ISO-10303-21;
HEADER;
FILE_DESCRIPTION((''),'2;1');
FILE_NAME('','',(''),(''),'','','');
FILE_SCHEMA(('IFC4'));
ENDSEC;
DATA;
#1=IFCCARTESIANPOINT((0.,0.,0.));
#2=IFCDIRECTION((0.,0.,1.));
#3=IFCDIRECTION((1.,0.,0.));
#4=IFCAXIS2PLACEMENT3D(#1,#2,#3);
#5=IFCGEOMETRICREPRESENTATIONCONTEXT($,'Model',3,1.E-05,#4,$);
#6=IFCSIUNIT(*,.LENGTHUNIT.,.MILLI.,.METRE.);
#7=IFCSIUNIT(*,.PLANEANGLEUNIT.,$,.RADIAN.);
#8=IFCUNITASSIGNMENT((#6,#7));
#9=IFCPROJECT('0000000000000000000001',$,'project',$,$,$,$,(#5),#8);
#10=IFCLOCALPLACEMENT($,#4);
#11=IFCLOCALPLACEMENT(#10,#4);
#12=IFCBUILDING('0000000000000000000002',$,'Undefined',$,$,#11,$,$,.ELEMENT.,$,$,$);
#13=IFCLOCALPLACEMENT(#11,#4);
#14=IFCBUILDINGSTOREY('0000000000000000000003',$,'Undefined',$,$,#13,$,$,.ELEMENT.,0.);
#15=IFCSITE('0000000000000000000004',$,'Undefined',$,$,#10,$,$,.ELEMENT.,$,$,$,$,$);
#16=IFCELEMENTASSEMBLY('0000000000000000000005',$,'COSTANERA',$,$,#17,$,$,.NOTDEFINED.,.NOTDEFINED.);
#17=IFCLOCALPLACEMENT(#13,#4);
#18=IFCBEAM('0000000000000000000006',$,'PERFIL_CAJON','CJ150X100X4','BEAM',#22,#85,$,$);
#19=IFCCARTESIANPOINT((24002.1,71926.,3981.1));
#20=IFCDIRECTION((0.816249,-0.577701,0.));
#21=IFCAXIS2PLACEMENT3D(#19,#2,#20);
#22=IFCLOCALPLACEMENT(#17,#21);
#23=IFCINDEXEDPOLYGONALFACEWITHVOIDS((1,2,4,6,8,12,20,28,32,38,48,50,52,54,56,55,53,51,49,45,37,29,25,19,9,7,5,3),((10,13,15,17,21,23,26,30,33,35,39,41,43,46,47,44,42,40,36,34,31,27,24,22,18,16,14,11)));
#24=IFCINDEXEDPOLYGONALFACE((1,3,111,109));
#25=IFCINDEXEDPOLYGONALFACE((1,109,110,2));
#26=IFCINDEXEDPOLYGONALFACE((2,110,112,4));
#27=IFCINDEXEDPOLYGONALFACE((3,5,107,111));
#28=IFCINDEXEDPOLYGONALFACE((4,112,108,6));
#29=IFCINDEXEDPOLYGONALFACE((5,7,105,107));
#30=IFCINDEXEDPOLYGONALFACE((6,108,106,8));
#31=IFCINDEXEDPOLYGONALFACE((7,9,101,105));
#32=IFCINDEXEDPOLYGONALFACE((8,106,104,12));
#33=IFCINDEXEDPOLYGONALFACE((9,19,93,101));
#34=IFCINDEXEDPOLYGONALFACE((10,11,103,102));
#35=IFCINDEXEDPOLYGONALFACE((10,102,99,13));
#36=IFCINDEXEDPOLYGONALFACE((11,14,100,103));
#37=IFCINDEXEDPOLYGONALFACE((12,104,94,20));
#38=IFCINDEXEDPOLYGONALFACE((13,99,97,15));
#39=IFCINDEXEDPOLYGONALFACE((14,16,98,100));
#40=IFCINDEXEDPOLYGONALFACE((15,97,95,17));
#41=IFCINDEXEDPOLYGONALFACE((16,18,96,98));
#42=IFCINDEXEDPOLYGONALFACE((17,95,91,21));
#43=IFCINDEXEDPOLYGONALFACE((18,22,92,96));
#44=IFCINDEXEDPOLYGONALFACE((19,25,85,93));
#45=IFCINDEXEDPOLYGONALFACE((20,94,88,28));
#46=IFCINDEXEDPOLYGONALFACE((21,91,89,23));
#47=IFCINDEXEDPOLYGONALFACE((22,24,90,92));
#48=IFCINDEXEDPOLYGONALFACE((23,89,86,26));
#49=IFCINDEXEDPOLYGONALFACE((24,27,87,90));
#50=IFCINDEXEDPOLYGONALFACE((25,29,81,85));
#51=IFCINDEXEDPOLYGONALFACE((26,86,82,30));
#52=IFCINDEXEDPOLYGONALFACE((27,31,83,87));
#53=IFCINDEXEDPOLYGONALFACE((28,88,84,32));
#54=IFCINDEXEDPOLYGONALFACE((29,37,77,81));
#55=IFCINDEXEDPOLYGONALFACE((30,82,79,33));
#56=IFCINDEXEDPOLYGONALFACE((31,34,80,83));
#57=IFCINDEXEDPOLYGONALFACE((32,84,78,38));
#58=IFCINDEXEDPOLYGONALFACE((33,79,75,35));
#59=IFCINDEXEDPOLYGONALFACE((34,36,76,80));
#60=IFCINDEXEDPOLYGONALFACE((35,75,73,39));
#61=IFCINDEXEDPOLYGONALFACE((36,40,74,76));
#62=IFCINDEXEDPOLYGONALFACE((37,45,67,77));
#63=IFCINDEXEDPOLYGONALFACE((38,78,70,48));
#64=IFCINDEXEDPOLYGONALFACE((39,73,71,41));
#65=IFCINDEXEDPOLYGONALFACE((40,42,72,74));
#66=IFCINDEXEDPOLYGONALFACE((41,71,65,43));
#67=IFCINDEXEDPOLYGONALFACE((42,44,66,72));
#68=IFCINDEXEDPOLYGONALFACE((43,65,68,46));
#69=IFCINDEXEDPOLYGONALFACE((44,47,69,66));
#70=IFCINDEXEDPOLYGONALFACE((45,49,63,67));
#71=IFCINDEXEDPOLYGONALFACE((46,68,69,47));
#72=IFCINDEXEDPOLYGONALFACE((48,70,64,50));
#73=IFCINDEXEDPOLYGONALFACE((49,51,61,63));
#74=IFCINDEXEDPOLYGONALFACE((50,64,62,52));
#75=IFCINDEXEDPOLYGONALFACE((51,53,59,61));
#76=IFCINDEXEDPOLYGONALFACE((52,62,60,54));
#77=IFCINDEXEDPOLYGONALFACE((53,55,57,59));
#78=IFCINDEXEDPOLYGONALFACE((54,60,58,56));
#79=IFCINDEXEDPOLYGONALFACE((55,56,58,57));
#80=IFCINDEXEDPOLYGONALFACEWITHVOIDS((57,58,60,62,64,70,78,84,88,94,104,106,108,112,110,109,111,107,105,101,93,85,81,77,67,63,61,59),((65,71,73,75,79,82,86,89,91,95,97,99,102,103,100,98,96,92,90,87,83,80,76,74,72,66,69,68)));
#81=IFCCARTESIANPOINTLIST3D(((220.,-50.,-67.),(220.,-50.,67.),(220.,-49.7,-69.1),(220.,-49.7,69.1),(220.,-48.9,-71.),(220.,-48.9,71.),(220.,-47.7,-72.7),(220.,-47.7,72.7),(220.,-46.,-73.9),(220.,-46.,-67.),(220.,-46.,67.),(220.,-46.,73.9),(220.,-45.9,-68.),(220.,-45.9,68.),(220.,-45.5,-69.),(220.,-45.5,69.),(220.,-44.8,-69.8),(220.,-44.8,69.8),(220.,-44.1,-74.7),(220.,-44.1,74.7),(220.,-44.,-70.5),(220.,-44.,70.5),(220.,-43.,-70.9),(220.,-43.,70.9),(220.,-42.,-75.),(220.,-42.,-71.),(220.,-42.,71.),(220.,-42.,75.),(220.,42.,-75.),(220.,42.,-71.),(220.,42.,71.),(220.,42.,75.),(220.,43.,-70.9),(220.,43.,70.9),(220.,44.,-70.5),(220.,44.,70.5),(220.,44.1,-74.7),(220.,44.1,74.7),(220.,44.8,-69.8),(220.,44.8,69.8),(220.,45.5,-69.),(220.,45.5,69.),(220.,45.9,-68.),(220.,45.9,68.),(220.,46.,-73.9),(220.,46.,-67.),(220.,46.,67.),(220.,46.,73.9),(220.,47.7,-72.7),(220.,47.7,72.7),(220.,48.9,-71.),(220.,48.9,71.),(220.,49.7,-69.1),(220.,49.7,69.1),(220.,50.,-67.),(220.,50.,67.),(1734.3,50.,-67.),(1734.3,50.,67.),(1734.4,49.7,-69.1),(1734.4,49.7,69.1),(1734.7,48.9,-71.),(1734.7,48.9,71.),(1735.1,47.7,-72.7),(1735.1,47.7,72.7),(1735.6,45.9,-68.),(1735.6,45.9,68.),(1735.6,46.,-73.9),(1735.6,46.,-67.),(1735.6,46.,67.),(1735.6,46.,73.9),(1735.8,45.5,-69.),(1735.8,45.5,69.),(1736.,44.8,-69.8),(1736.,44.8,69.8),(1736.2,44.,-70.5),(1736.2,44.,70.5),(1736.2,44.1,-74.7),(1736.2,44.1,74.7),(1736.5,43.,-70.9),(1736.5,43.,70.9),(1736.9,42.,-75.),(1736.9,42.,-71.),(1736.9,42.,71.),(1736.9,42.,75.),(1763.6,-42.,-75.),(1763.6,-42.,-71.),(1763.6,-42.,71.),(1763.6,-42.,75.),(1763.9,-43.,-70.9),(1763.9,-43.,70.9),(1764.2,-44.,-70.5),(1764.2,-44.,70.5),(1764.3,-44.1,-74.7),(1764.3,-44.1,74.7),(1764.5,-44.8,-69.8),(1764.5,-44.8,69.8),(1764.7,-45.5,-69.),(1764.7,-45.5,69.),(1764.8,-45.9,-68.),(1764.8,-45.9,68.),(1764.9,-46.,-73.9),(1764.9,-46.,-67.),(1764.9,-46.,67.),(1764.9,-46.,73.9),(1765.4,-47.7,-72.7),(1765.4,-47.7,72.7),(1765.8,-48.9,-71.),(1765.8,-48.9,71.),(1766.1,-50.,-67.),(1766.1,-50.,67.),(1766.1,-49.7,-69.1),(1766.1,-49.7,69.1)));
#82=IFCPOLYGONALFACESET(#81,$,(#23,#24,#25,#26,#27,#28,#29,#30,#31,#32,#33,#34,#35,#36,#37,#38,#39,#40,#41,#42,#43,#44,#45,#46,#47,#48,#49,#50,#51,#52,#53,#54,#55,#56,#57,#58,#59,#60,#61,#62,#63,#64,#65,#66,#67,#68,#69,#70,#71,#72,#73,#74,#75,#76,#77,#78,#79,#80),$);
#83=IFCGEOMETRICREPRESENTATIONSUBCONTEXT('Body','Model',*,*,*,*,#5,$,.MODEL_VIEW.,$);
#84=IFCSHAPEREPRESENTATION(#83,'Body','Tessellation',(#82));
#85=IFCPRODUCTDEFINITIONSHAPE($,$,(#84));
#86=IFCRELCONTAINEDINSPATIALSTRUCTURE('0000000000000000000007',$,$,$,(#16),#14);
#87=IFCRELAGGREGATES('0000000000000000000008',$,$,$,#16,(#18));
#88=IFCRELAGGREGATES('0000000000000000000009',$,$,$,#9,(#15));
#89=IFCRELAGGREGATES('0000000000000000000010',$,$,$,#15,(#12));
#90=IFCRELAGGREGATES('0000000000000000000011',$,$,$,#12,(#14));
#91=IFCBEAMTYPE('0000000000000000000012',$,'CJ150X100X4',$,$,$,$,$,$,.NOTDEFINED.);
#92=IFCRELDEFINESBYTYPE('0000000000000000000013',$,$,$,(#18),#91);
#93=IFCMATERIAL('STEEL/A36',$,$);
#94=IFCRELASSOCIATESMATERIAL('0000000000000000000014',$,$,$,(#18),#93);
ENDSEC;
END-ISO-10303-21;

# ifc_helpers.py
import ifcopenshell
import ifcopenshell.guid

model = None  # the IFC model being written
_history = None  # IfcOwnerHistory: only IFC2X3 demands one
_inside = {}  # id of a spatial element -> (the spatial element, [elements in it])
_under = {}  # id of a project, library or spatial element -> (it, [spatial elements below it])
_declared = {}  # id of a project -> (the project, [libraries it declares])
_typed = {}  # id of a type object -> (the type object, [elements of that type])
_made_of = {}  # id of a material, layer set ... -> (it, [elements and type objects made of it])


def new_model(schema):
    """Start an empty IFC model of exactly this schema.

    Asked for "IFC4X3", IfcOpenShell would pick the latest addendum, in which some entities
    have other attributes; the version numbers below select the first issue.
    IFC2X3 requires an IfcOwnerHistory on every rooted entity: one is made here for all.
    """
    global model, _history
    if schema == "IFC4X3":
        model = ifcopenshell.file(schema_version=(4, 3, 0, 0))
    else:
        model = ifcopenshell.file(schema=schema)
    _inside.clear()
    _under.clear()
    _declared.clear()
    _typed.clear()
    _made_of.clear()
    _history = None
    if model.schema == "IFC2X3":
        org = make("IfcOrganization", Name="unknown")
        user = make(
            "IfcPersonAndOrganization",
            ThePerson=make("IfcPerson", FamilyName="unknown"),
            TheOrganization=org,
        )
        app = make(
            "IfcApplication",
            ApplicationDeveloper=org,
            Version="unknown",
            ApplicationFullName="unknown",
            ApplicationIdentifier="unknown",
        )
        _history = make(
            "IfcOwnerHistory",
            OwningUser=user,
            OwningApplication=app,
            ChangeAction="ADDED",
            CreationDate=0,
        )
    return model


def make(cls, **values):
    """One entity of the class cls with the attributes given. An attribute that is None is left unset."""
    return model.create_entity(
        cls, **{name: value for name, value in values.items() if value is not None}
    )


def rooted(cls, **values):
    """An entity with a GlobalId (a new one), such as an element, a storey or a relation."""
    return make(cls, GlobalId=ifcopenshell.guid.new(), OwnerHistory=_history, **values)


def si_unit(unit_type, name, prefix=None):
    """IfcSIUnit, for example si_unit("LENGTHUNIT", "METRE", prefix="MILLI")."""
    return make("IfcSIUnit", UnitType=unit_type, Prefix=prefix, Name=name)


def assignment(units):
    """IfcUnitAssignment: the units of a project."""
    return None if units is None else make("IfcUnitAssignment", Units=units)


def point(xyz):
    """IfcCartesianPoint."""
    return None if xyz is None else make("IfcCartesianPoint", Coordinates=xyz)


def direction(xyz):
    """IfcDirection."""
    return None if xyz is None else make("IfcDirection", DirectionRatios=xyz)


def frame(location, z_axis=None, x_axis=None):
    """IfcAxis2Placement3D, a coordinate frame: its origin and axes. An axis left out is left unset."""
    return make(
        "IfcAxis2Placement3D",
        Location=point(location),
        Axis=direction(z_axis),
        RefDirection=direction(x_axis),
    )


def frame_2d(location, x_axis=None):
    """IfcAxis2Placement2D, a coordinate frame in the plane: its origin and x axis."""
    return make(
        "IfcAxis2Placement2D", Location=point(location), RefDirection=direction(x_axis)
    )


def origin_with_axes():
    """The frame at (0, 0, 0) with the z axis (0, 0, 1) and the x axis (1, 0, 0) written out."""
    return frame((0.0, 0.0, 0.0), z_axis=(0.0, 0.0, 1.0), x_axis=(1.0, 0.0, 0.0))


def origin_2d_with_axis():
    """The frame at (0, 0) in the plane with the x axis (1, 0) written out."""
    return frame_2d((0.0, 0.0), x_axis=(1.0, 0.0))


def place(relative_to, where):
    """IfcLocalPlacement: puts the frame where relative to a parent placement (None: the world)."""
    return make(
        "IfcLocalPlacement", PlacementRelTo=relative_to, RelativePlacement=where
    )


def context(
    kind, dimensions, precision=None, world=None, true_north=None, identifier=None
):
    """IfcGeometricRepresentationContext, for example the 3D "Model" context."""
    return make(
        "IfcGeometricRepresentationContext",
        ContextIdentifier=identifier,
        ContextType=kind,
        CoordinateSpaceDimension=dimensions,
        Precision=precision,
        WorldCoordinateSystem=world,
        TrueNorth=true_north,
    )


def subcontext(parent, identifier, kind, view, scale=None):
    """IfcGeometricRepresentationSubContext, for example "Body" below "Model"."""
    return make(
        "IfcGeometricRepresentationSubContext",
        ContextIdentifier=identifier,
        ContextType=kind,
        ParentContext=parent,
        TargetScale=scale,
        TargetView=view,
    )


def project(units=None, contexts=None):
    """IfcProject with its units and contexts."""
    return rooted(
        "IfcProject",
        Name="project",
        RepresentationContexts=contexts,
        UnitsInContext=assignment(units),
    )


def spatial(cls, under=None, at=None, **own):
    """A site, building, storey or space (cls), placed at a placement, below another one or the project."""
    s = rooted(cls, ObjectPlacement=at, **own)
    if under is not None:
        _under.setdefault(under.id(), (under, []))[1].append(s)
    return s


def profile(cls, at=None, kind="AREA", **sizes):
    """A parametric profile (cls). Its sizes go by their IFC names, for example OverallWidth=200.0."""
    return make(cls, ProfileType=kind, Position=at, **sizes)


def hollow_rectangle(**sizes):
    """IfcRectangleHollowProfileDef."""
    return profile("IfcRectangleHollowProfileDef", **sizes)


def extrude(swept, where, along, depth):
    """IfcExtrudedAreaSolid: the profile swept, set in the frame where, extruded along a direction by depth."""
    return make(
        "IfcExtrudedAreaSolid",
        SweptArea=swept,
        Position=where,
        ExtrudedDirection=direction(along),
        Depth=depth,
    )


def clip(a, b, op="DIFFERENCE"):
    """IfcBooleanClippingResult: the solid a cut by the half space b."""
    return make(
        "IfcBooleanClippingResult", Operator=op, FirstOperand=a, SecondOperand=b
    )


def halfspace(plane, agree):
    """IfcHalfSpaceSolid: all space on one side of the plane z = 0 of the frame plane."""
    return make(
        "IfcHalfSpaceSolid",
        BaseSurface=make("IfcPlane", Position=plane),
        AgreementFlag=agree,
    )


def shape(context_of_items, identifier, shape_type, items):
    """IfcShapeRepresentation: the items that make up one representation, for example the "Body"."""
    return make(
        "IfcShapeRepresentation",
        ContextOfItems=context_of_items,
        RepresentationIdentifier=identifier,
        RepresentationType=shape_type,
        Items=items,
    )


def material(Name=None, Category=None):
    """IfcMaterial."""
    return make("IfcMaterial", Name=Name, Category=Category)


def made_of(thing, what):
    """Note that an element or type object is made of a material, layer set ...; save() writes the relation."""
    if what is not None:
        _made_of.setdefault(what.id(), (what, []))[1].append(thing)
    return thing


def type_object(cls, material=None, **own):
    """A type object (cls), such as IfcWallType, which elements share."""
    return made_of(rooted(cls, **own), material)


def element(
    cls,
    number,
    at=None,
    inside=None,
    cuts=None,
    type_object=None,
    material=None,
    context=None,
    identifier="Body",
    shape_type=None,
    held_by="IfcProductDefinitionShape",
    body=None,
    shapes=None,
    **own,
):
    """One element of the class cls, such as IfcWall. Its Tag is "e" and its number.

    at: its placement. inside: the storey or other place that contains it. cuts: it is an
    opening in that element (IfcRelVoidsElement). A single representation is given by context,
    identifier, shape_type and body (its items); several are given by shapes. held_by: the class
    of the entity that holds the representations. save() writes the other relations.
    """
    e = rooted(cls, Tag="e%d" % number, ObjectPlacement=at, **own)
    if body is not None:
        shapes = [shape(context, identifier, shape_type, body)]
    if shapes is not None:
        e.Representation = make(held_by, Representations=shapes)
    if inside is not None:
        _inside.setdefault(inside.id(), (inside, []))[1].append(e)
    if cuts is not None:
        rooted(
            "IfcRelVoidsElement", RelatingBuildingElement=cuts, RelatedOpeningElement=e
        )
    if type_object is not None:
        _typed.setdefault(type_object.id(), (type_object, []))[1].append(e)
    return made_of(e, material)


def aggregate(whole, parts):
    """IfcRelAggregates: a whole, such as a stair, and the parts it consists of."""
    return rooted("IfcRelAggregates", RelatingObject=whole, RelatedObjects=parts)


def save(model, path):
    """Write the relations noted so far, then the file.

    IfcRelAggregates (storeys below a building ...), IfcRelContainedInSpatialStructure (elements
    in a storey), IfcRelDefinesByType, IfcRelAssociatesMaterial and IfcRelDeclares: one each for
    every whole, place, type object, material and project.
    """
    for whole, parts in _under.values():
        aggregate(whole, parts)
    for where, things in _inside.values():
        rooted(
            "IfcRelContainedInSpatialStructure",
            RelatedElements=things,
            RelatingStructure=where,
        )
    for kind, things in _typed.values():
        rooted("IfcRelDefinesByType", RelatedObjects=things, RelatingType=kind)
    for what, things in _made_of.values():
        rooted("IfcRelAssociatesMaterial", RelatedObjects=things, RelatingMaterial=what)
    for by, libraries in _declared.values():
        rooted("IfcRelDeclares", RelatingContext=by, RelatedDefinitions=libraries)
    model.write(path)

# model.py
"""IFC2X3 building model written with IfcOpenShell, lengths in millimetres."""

from ifc_helpers import new_model, si_unit, frame, origin_with_axes, origin_2d_with_axis, place, context, subcontext, project, spatial, hollow_rectangle, extrude, clip, halfspace, material, type_object, element, aggregate, save


model = new_model("IFC2X3")

# Units and contexts
model_context = context("Model", 3, precision=1e-05, world=origin_with_axes())
body_context = subcontext(model_context, "Body", "Model", "MODEL_VIEW")
ifc_project = project(units=[si_unit("LENGTHUNIT", "METRE", prefix="MILLI"), si_unit("PLANEANGLEUNIT", "RADIAN")], contexts=[model_context])

# Site, building, storey
site_placement = place(None, origin_with_axes())
site = spatial("IfcSite", under=ifc_project, at=site_placement, Name="Undefined", CompositionType="ELEMENT")
building_placement = place(site_placement, origin_with_axes())
building = spatial("IfcBuilding", under=site, at=building_placement, Name="Undefined", CompositionType="ELEMENT")
storey_placement = place(building_placement, origin_with_axes())
storey = spatial("IfcBuildingStorey", under=building, at=storey_placement, Name="Undefined", CompositionType="ELEMENT", Elevation=0.0)

# Shared definitions
ifc_material_1 = material(Name="STEEL/A36")

# Element assembly, beam
assembly_1_placement = place(storey_placement, origin_with_axes())
assembly_1 = element("IfcElementAssembly", 1, at=assembly_1_placement, inside=storey, Name="COSTANERA", AssemblyPlace="NOTDEFINED", PredefinedType="NOTDEFINED")
beam_type_1 = type_object("IfcBeamType", Name="CJ150X100X4", PredefinedType="NOTDEFINED")
beam_1_placement = place(assembly_1_placement, frame((24002.1, 71926.0, 3981.1), z_axis=(0.0, 0.0, 1.0), x_axis=(0.816249, -0.577701, 0.0)))
beam_1 = element("IfcBeam", 2, at=beam_1_placement, type_object=beam_type_1, material=ifc_material_1, Name="PERFIL_CAJON", Description="CJ150X100X4", ObjectType="BEAM", context=body_context, shape_type="Clipping", body=[
    clip(clip(extrude(hollow_rectangle(XDim=100.0, YDim=150.0, WallThickness=4.0, InnerFilletRadius=4.0, OuterFilletRadius=8.0, at=origin_2d_with_axis()), frame((1840.1, 0.0, 0.0), z_axis=(-1.0, 0.0, 0.0), x_axis=(0.0, -1.0, 0.0)), (0.0, 0.0, 1.0), 1840.2), halfspace(frame((1766.1, -50.0, 0.0), z_axis=(0.952956, 0.30311, 0.0), x_axis=(0.0, 0.0, 1.0)), False)), halfspace(frame((220.0, 44.8, -480.0), z_axis=(-1.0, 0.0, 0.0), x_axis=(0.0, 0.0, 1.0)), False)),
])

aggregate(assembly_1, [beam_1])

save(model, "model.ifc")
